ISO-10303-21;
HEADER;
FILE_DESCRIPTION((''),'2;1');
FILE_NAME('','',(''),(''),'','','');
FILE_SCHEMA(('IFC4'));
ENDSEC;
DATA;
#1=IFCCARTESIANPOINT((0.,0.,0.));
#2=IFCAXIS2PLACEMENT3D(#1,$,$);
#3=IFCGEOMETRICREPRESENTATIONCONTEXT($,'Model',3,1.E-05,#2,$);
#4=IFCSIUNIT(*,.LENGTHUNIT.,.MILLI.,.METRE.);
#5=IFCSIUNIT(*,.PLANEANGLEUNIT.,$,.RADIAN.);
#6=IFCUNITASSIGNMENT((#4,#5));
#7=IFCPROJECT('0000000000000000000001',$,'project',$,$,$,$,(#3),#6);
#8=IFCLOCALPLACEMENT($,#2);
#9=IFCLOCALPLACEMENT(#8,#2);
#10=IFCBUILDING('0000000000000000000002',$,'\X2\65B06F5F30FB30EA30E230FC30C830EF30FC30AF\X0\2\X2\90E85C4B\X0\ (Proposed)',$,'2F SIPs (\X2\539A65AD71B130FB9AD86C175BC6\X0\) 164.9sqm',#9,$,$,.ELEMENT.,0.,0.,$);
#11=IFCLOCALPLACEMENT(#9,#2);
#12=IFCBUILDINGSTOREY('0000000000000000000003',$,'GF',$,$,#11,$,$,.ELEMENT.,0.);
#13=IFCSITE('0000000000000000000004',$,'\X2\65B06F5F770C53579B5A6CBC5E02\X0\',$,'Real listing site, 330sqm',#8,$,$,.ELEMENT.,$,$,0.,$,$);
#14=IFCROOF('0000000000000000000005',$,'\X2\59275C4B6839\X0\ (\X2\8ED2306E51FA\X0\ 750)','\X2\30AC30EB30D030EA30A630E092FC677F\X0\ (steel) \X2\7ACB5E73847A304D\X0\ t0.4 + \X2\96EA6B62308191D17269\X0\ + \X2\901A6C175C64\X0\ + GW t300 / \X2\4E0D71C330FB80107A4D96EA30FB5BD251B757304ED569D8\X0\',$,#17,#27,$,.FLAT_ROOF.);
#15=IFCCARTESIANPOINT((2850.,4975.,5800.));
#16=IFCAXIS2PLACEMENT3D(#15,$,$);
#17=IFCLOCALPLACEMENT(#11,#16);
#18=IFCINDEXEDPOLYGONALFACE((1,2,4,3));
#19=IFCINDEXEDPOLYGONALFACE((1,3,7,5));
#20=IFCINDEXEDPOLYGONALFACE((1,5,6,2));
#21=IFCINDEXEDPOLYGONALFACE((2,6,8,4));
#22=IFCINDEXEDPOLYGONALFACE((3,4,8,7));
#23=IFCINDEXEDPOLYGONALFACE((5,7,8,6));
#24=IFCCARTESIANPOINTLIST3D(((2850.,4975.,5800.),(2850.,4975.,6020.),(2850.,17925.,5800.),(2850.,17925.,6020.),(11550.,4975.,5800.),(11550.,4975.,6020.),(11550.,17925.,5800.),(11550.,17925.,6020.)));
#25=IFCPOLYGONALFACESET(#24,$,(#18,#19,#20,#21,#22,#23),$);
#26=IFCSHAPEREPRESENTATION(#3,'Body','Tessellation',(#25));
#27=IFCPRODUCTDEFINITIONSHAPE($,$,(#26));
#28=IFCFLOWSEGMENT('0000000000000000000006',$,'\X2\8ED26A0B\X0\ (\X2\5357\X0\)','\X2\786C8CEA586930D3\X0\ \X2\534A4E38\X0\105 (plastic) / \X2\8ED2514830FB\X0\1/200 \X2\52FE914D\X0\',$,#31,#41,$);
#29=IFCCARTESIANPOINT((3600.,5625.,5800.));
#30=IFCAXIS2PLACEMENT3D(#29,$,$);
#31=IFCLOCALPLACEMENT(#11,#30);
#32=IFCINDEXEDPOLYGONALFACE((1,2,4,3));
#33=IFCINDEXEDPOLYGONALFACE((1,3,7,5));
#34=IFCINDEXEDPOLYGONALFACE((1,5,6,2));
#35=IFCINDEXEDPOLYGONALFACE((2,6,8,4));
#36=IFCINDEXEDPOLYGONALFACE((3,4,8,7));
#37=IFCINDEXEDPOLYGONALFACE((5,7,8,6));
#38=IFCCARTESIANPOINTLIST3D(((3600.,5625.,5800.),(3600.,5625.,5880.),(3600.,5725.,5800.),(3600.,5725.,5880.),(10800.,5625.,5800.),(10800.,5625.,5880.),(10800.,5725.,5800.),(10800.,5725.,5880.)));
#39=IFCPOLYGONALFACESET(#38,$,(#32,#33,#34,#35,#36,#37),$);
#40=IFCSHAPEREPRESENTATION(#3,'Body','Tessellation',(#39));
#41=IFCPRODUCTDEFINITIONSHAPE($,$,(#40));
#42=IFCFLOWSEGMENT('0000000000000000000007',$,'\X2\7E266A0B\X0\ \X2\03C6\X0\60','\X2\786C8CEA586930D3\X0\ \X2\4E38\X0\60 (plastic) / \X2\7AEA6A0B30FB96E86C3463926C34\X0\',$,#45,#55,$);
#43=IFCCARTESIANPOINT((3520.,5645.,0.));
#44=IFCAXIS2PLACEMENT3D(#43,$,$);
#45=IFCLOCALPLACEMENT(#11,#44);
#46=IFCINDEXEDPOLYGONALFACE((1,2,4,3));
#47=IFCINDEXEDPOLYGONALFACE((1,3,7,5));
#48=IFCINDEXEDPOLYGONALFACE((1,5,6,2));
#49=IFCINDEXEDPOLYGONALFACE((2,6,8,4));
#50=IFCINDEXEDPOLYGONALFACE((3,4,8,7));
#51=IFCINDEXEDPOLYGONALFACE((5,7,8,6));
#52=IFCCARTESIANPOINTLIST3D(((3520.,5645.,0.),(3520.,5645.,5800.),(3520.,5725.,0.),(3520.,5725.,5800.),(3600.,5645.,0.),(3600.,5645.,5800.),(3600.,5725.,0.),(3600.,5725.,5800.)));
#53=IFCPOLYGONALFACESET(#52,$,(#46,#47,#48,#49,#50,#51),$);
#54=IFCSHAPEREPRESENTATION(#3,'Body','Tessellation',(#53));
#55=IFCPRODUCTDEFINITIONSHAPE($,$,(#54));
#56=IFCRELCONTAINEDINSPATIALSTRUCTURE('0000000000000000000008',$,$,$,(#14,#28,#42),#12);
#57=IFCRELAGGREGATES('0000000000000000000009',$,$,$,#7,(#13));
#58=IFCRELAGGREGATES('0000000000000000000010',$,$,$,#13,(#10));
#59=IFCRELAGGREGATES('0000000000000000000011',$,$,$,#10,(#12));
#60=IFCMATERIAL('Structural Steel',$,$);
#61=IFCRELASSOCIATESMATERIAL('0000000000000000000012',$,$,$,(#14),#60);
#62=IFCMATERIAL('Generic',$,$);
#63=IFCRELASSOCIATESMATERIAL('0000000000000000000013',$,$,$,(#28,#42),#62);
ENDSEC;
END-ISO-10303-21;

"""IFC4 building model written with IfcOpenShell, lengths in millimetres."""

from ifc_helpers import new_model, si_unit, frame, frame_2d, origin, place, context, project, spatial, rectangle, extrude, material, element, save


model = new_model("IFC4")

# Units and contexts
model_context = context("Model", 3, precision=1e-05, world=origin())
ifc_project = project(units=[si_unit("LENGTHUNIT", "METRE", prefix="MILLI"), si_unit("PLANEANGLEUNIT", "RADIAN")], contexts=[model_context])

# Site, building, storey
site_placement = place(None, origin())
site = spatial("IfcSite", under=ifc_project, at=site_placement, Name="新潟県南魚沼市", ObjectType="Real listing site, 330sqm", CompositionType="ELEMENT", RefElevation=0.0)
building_placement = place(site_placement, origin())
building = spatial("IfcBuilding", under=site, at=building_placement, Name="新潟・リモートワーク2部屋 (Proposed)", ObjectType="2F SIPs (厚断熱・高気密) 164.9sqm", CompositionType="ELEMENT", ElevationOfRefHeight=0.0, ElevationOfTerrain=0.0)
storey_placement = place(building_placement, origin())
storey = spatial("IfcBuildingStorey", under=building, at=storey_placement, Name="GF", CompositionType="ELEMENT", Elevation=0.0)

# Roof
ifc_material_1 = material(Name="Structural Steel")
roof_placement = place(storey_placement, frame((2850.0, 4975.0, 5800.0)))
element("IfcRoof", 1, at=roof_placement, inside=storey, material=ifc_material_1, Name="大屋根 (軒の出 750)", Description="ガルバリウム鋼板 (steel) 立平葺き t0.4 + 雪止め金物 + 通気層 + GW t300 / 不燃・耐積雪・寒冷地仕様", PredefinedType="FLAT_ROOF", context=model_context, shape_type="SweptSolid", body=[
    extrude(rectangle(XDim=8700.0, YDim=12950.0, at=frame_2d((4350.0, 6475.0))), frame((2850.0, 4975.0, 5800.0)), (0.0, 0.0, 1.0), 220.0),
])

# Flow segments
ifc_material_2 = material(Name="Generic")
flow_segment_1_placement = place(storey_placement, frame((3600.0, 5625.0, 5800.0)))
element("IfcFlowSegment", 2, at=flow_segment_1_placement, inside=storey, material=ifc_material_2, Name="軒樋 (南)", Description="硬質塩ビ 半丸105 (plastic) / 軒先・1/200 勾配", context=model_context, shape_type="SweptSolid", body=[
    extrude(rectangle(XDim=7200.0, YDim=100.0, at=frame_2d((3600.0, 50.0))), frame((3600.0, 5625.0, 5800.0)), (0.0, 0.0, 1.0), 80.0),
])
flow_segment_2_placement = place(storey_placement, frame((3520.0, 5645.0, 0.0)))
element("IfcFlowSegment", 3, at=flow_segment_2_placement, inside=storey, material=ifc_material_2, Name="縦樋 φ60", Description="硬質塩ビ 丸60 (plastic) / 竪樋・雨水排水", context=model_context, shape_type="SweptSolid", body=[
    extrude(rectangle(XDim=80.0, YDim=80.0, at=frame_2d((40.0, 40.0))), frame((3520.0, 5645.0, 0.0)), (0.0, 0.0, 1.0), 5800.0),
])

save(model, "model.ifc")
